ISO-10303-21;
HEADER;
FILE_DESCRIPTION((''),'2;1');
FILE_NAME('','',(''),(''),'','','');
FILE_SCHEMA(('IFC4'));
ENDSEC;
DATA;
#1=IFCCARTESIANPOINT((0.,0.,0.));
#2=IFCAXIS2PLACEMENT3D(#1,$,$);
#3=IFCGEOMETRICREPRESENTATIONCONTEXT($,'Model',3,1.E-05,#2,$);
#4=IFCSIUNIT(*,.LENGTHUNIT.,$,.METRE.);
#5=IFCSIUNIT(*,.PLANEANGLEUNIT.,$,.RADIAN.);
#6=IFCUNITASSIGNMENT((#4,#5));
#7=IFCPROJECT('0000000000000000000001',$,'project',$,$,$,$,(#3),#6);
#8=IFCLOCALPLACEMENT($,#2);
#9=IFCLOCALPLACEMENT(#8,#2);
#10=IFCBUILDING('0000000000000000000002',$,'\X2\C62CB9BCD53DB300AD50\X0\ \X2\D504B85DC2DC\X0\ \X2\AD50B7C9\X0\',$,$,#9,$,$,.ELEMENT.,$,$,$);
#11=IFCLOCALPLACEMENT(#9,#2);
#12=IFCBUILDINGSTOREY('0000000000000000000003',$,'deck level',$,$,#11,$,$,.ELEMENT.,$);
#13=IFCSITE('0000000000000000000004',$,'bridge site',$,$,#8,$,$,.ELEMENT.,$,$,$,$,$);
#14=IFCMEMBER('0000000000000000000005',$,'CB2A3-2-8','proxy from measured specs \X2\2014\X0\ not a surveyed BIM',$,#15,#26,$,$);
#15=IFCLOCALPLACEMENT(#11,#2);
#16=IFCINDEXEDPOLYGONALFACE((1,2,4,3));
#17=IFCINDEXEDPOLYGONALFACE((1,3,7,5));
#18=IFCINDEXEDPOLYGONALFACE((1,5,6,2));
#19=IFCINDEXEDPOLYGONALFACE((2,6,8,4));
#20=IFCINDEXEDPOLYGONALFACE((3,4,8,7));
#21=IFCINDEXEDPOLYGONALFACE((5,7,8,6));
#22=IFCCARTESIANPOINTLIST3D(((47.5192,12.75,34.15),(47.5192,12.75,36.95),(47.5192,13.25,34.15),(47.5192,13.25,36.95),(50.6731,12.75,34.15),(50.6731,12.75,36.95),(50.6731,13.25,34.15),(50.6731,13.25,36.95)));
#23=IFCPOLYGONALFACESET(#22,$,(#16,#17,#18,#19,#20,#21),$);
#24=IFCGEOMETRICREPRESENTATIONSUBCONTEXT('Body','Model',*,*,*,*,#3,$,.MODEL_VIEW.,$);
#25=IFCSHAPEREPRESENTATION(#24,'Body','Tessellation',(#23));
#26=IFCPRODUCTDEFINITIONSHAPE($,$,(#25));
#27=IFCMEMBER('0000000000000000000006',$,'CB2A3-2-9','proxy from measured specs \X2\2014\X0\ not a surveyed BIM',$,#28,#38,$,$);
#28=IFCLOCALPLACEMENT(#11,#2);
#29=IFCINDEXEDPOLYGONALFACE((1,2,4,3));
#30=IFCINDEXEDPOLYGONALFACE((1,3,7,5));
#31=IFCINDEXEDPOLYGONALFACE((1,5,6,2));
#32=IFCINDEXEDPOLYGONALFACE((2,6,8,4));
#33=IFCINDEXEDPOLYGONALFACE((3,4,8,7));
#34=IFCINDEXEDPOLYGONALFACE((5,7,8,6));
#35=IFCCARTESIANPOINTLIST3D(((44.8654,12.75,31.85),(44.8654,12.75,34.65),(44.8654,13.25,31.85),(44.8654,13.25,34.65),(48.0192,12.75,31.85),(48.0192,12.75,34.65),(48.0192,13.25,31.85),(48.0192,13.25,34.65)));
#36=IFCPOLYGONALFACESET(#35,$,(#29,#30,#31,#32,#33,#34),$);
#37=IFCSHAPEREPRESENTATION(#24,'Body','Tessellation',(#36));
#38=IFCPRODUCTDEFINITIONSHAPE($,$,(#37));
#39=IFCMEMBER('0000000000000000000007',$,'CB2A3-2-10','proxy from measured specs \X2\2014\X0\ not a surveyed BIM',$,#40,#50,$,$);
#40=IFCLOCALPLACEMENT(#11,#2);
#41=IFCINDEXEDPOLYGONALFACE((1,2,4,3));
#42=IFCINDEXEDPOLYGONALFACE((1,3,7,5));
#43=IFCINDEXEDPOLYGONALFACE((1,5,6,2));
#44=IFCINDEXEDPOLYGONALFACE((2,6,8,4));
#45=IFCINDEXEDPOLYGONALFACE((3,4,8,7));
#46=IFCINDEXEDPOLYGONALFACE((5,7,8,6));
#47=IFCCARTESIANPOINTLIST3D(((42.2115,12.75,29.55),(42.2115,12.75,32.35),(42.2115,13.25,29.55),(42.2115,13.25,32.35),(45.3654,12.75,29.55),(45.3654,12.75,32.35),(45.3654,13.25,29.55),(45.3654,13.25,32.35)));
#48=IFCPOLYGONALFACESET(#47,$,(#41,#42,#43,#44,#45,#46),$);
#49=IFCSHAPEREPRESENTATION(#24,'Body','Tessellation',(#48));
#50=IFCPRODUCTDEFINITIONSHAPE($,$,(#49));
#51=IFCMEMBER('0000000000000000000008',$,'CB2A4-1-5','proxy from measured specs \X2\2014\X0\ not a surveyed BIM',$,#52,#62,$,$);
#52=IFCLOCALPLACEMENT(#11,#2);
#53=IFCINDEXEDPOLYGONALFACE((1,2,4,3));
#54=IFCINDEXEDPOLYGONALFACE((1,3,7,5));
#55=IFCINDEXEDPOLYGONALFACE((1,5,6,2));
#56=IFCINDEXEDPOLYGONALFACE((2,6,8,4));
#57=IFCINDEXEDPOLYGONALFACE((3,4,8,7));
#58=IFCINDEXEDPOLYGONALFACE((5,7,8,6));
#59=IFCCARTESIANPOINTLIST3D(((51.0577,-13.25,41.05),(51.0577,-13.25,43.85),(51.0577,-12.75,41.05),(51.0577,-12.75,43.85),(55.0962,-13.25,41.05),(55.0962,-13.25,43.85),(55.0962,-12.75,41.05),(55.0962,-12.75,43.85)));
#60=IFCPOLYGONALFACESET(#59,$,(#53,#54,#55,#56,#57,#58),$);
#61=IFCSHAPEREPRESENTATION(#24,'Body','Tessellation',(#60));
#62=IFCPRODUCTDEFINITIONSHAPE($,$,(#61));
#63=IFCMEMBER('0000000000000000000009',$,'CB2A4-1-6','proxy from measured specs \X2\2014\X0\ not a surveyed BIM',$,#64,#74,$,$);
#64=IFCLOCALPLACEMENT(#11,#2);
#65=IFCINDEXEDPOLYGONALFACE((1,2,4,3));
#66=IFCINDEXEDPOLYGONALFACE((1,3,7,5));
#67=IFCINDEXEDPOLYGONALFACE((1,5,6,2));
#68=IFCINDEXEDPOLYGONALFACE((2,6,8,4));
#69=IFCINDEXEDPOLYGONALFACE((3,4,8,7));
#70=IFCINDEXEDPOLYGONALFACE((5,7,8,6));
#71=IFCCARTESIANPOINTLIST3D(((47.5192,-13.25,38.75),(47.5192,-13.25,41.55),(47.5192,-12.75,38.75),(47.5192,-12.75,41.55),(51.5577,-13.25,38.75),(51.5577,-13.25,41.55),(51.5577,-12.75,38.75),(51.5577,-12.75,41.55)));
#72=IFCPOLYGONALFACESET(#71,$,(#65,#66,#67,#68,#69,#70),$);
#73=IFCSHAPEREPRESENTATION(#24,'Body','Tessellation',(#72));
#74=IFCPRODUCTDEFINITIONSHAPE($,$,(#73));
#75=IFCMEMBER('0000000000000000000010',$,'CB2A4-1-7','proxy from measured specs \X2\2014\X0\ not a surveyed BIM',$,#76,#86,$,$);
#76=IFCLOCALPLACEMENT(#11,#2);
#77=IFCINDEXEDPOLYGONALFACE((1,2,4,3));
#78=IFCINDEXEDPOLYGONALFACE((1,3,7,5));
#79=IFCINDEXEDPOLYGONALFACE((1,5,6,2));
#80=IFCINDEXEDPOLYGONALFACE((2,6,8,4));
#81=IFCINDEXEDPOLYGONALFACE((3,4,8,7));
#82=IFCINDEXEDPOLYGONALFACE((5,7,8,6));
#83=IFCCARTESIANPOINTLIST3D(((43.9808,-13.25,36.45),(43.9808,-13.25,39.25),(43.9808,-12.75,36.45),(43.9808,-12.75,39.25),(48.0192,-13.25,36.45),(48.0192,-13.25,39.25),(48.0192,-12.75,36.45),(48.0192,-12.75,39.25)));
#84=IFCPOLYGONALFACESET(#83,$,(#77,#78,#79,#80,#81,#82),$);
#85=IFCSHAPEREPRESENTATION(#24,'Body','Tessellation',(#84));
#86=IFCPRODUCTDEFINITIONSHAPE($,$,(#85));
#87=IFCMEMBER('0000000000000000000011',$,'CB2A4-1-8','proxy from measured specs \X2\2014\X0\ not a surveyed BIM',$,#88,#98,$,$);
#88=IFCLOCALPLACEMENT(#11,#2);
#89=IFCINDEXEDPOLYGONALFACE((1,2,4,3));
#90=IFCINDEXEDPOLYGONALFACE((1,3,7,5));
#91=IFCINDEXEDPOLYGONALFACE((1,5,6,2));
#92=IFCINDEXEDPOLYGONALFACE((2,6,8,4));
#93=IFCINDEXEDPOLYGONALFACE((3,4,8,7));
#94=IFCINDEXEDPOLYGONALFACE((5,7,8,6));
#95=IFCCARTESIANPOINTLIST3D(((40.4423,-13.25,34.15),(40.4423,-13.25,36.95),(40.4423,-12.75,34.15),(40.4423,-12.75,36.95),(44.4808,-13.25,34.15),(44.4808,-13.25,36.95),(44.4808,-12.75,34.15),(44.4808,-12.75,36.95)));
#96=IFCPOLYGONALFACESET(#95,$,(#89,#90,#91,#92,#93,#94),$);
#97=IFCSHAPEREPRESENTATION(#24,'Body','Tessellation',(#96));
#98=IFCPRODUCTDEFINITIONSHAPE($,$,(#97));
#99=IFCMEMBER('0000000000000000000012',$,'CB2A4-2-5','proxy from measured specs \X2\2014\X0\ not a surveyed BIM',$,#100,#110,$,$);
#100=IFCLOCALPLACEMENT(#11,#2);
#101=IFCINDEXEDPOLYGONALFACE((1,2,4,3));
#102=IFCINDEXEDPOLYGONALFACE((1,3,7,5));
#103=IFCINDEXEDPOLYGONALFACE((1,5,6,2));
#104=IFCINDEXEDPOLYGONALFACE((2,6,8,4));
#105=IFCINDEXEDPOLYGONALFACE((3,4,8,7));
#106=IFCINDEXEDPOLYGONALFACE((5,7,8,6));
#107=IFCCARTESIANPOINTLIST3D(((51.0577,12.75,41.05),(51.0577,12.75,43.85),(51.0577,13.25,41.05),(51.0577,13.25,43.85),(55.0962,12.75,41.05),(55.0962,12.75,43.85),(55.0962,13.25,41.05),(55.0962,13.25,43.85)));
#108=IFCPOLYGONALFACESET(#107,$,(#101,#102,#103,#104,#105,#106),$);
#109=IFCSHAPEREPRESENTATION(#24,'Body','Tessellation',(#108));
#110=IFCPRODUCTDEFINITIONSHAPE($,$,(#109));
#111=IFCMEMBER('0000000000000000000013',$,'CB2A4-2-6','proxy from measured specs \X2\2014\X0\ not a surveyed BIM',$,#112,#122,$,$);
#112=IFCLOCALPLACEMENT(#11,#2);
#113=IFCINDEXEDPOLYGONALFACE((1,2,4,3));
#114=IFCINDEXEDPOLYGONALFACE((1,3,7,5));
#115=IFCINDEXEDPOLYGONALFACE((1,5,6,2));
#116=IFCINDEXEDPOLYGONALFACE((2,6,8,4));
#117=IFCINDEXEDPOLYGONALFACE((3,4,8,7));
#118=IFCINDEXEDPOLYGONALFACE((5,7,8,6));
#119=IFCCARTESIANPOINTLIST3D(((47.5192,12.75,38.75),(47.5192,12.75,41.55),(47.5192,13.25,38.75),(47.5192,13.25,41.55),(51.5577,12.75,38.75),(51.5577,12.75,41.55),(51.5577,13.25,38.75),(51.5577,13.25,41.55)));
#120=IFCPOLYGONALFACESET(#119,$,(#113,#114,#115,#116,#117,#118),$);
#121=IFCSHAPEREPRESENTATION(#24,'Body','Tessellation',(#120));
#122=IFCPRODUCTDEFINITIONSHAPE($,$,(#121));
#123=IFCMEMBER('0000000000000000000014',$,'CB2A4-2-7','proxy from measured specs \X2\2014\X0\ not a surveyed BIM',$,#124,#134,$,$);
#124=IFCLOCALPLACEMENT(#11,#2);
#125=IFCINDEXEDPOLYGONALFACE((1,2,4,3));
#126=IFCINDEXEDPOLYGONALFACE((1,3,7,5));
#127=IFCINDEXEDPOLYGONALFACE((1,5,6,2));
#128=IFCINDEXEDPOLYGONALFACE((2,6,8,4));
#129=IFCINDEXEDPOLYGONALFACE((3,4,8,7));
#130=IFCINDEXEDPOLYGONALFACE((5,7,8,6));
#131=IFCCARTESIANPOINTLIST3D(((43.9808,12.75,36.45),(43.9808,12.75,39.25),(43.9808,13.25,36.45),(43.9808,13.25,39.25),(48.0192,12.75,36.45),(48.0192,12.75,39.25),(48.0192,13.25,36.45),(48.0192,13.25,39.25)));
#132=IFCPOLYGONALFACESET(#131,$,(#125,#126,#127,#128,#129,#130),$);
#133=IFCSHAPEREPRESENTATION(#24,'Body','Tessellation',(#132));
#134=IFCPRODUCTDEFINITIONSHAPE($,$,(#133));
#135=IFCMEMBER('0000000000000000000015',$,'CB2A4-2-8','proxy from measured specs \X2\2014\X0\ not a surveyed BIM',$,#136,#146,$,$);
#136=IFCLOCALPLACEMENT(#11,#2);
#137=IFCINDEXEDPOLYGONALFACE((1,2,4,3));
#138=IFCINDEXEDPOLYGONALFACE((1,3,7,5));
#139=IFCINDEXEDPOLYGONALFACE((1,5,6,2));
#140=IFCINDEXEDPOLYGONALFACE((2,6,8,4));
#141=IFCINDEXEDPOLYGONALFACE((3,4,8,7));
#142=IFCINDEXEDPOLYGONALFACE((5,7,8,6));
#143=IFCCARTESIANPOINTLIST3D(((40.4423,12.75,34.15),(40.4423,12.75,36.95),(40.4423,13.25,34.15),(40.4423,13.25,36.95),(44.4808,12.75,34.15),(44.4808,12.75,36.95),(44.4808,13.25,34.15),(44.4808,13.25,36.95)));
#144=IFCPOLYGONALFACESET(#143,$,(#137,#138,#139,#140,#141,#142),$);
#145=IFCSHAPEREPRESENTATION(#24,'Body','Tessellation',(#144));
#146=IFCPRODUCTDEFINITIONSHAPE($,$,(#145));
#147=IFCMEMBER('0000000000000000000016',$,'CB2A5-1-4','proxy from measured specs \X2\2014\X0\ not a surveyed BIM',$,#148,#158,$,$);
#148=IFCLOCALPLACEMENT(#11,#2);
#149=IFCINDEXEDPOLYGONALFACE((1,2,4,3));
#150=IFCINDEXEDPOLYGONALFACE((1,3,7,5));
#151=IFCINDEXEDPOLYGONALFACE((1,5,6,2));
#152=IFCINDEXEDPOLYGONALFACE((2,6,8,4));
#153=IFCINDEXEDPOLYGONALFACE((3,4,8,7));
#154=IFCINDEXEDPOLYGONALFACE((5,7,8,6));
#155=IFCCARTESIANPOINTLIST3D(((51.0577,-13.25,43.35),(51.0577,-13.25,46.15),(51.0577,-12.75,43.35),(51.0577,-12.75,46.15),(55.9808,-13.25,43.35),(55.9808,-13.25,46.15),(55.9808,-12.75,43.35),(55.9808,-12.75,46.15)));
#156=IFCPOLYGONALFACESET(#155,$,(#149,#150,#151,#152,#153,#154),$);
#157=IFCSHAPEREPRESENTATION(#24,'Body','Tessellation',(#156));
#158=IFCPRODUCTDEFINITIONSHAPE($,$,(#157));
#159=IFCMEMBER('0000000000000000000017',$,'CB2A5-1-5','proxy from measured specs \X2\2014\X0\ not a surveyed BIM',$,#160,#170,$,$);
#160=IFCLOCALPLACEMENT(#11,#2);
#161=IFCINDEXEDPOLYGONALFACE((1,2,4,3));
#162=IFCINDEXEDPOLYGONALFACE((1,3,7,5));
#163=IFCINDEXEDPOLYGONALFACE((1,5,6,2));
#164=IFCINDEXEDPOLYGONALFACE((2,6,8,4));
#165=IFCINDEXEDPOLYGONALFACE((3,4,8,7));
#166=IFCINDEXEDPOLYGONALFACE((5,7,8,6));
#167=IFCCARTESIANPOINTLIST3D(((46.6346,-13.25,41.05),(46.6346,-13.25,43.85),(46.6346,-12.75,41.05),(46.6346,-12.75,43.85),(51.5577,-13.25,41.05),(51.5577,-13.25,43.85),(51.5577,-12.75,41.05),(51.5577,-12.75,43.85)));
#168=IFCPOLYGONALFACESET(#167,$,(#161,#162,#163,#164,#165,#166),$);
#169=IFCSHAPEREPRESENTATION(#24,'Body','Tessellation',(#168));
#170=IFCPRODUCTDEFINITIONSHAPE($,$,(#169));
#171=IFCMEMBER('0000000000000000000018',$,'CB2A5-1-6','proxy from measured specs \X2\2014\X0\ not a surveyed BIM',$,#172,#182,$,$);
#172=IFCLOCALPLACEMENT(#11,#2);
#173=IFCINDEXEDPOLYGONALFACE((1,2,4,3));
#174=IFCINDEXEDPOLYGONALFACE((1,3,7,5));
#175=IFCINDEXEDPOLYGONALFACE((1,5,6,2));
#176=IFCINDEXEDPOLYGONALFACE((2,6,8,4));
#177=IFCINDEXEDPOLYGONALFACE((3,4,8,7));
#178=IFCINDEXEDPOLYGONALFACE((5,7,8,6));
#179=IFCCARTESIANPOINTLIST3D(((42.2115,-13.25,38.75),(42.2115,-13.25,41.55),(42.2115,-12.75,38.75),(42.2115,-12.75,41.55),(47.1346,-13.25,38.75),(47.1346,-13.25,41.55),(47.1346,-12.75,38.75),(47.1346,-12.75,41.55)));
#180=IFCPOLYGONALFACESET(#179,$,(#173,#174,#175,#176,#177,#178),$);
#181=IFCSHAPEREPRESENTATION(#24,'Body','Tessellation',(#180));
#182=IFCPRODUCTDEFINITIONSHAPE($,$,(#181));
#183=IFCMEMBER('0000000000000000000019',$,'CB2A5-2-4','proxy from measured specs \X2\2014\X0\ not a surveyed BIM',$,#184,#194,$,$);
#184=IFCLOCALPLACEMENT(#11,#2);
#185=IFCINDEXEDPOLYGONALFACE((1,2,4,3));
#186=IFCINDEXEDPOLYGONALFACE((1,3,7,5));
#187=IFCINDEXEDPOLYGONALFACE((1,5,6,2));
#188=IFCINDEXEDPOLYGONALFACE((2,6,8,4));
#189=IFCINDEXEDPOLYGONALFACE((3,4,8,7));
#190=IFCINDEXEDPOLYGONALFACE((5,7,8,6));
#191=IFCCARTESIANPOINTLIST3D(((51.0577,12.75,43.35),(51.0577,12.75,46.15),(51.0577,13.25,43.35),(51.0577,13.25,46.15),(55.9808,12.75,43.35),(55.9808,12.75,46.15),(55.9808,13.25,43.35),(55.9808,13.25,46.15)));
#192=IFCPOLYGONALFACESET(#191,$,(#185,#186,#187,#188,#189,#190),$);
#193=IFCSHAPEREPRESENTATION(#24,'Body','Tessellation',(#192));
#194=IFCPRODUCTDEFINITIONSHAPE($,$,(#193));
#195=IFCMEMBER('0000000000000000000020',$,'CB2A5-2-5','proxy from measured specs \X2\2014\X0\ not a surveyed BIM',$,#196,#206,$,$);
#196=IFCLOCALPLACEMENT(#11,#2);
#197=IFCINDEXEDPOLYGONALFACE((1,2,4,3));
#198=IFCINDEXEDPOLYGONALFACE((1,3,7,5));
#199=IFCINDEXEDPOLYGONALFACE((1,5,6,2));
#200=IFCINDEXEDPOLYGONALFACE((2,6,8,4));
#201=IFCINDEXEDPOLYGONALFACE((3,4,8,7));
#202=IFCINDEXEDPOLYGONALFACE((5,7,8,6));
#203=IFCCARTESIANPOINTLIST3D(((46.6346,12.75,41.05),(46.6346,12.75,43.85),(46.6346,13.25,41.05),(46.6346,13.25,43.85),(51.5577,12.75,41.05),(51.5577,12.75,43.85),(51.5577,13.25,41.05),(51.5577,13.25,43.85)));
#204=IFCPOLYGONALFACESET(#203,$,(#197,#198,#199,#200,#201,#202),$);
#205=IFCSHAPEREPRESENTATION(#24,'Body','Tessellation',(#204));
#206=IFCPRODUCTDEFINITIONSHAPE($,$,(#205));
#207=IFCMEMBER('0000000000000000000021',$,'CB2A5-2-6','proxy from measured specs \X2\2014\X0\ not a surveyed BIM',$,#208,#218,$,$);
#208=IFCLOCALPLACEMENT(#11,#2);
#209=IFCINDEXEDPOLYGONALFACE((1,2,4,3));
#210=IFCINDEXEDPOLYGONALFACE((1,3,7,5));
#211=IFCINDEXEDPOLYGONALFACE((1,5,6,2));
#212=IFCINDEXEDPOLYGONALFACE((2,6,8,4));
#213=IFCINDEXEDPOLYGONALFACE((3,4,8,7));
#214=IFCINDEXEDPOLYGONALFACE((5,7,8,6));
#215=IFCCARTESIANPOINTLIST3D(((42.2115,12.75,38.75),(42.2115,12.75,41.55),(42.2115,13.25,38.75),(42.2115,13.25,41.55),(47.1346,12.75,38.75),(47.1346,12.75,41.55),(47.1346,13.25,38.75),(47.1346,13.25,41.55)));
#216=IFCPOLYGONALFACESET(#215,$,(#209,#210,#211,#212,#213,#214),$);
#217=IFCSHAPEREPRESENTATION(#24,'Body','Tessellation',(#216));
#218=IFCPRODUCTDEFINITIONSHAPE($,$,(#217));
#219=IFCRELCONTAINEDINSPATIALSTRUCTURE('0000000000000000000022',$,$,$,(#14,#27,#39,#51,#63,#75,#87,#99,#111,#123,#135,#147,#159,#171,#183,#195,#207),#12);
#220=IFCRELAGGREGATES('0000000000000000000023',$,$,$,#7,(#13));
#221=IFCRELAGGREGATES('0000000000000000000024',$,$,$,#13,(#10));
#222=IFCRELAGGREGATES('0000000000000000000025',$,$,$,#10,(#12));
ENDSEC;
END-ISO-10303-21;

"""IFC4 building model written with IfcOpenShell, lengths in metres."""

from ifc_helpers import new_model, si_unit, frame, origin, origin_2d, place, context, subcontext, project, spatial, rectangle, extrude, element, save


model = new_model("IFC4")

# Units and contexts
model_context = context("Model", 3, precision=1e-05, world=origin())
body_context = subcontext(model_context, "Body", "Model", "MODEL_VIEW")
ifc_project = project(units=[si_unit("LENGTHUNIT", "METRE"), si_unit("PLANEANGLEUNIT", "RADIAN")], contexts=[model_context])

# Site, building, storey
site_placement = place(None, origin())
site = spatial("IfcSite", under=ifc_project, at=site_placement, Name="bridge site", CompositionType="ELEMENT")
building_placement = place(site_placement, origin())
building = spatial("IfcBuilding", under=site, at=building_placement, Name="올림픽대교 프록시 교량", CompositionType="ELEMENT")
storey_placement = place(building_placement, origin())
storey = spatial("IfcBuildingStorey", under=building, at=storey_placement, Name="deck level", CompositionType="ELEMENT")

# Members
member_1_placement = place(storey_placement, frame((49.0962, 13.0, 34.15)))
element("IfcMember", 1, at=member_1_placement, inside=storey, Name="CB2A3-2-8", Description="proxy from measured specs — not a surveyed BIM", context=body_context, shape_type="SweptSolid", body=[
    extrude(rectangle(XDim=3.1538, YDim=0.5, at=origin_2d()), origin(), (0.0, 0.0, 1.0), 2.8),
])
member_2_placement = place(storey_placement, frame((46.4423, 13.0, 31.85)))
element("IfcMember", 2, at=member_2_placement, inside=storey, Name="CB2A3-2-9", Description="proxy from measured specs — not a surveyed BIM", context=body_context, shape_type="SweptSolid", body=[
    extrude(rectangle(XDim=3.1538, YDim=0.5, at=origin_2d()), origin(), (0.0, 0.0, 1.0), 2.8),
])
member_3_placement = place(storey_placement, frame((43.7885, 13.0, 29.55)))
element("IfcMember", 3, at=member_3_placement, inside=storey, Name="CB2A3-2-10", Description="proxy from measured specs — not a surveyed BIM", context=body_context, shape_type="SweptSolid", body=[
    extrude(rectangle(XDim=3.1538, YDim=0.5, at=origin_2d()), origin(), (0.0, 0.0, 1.0), 2.8),
])
member_4_placement = place(storey_placement, frame((53.0769, -13.0, 41.05)))
element("IfcMember", 4, at=member_4_placement, inside=storey, Name="CB2A4-1-5", Description="proxy from measured specs — not a surveyed BIM", context=body_context, shape_type="SweptSolid", body=[
    extrude(rectangle(XDim=4.0385, YDim=0.5, at=origin_2d()), origin(), (0.0, 0.0, 1.0), 2.8),
])
member_5_placement = place(storey_placement, frame((49.5385, -13.0, 38.75)))
element("IfcMember", 5, at=member_5_placement, inside=storey, Name="CB2A4-1-6", Description="proxy from measured specs — not a surveyed BIM", context=body_context, shape_type="SweptSolid", body=[
    extrude(rectangle(XDim=4.0385, YDim=0.5, at=origin_2d()), origin(), (0.0, 0.0, 1.0), 2.8),
])
member_6_placement = place(storey_placement, frame((46.0, -13.0, 36.45)))
element("IfcMember", 6, at=member_6_placement, inside=storey, Name="CB2A4-1-7", Description="proxy from measured specs — not a surveyed BIM", context=body_context, shape_type="SweptSolid", body=[
    extrude(rectangle(XDim=4.0385, YDim=0.5, at=origin_2d()), origin(), (0.0, 0.0, 1.0), 2.8),
])
member_7_placement = place(storey_placement, frame((42.4615, -13.0, 34.15)))
element("IfcMember", 7, at=member_7_placement, inside=storey, Name="CB2A4-1-8", Description="proxy from measured specs — not a surveyed BIM", context=body_context, shape_type="SweptSolid", body=[
    extrude(rectangle(XDim=4.0385, YDim=0.5, at=origin_2d()), origin(), (0.0, 0.0, 1.0), 2.8),
])
member_8_placement = place(storey_placement, frame((53.0769, 13.0, 41.05)))
element("IfcMember", 8, at=member_8_placement, inside=storey, Name="CB2A4-2-5", Description="proxy from measured specs — not a surveyed BIM", context=body_context, shape_type="SweptSolid", body=[
    extrude(rectangle(XDim=4.0385, YDim=0.5, at=origin_2d()), origin(), (0.0, 0.0, 1.0), 2.8),
])
member_9_placement = place(storey_placement, frame((49.5385, 13.0, 38.75)))
element("IfcMember", 9, at=member_9_placement, inside=storey, Name="CB2A4-2-6", Description="proxy from measured specs — not a surveyed BIM", context=body_context, shape_type="SweptSolid", body=[
    extrude(rectangle(XDim=4.0385, YDim=0.5, at=origin_2d()), origin(), (0.0, 0.0, 1.0), 2.8),
])
member_10_placement = place(storey_placement, frame((46.0, 13.0, 36.45)))
element("IfcMember", 10, at=member_10_placement, inside=storey, Name="CB2A4-2-7", Description="proxy from measured specs — not a surveyed BIM", context=body_context, shape_type="SweptSolid", body=[
    extrude(rectangle(XDim=4.0385, YDim=0.5, at=origin_2d()), origin(), (0.0, 0.0, 1.0), 2.8),
])
member_11_placement = place(storey_placement, frame((42.4615, 13.0, 34.15)))
element("IfcMember", 11, at=member_11_placement, inside=storey, Name="CB2A4-2-8", Description="proxy from measured specs — not a surveyed BIM", context=body_context, shape_type="SweptSolid", body=[
    extrude(rectangle(XDim=4.0385, YDim=0.5, at=origin_2d()), origin(), (0.0, 0.0, 1.0), 2.8),
])
member_12_placement = place(storey_placement, frame((53.5192, -13.0, 43.35)))
element("IfcMember", 12, at=member_12_placement, inside=storey, Name="CB2A5-1-4", Description="proxy from measured specs — not a surveyed BIM", context=body_context, shape_type="SweptSolid", body=[
    extrude(rectangle(XDim=4.9231, YDim=0.5, at=origin_2d()), origin(), (0.0, 0.0, 1.0), 2.8),
])
for number, where, name in (
    (13, (49.0962, -13.0, 41.05), "CB2A5-1-5"),
    (14, (44.6731, -13.0, 38.75), "CB2A5-1-6"),
):
    element("IfcMember", number, at=place(storey_placement, frame(where)), inside=storey, Name=name, Description="proxy from measured specs — not a surveyed BIM", context=body_context, shape_type="SweptSolid", body=[
        extrude(rectangle(XDim=4.9231, YDim=0.5, at=origin_2d()), origin(), (0.0, 0.0, 1.0), 2.8),
    ])
member_13_placement = place(storey_placement, frame((53.5192, 13.0, 43.35)))
element("IfcMember", 15, at=member_13_placement, inside=storey, Name="CB2A5-2-4", Description="proxy from measured specs — not a surveyed BIM", context=body_context, shape_type="SweptSolid", body=[
    extrude(rectangle(XDim=4.9231, YDim=0.5, at=origin_2d()), origin(), (0.0, 0.0, 1.0), 2.8),
])
for number, where, name in (
    (16, (49.0962, 13.0, 41.05), "CB2A5-2-5"),
    (17, (44.6731, 13.0, 38.75), "CB2A5-2-6"),
):
    element("IfcMember", number, at=place(storey_placement, frame(where)), inside=storey, Name=name, Description="proxy from measured specs — not a surveyed BIM", context=body_context, shape_type="SweptSolid", body=[
        extrude(rectangle(XDim=4.9231, YDim=0.5, at=origin_2d()), origin(), (0.0, 0.0, 1.0), 2.8),
    ])

save(model, "model.ifc")
